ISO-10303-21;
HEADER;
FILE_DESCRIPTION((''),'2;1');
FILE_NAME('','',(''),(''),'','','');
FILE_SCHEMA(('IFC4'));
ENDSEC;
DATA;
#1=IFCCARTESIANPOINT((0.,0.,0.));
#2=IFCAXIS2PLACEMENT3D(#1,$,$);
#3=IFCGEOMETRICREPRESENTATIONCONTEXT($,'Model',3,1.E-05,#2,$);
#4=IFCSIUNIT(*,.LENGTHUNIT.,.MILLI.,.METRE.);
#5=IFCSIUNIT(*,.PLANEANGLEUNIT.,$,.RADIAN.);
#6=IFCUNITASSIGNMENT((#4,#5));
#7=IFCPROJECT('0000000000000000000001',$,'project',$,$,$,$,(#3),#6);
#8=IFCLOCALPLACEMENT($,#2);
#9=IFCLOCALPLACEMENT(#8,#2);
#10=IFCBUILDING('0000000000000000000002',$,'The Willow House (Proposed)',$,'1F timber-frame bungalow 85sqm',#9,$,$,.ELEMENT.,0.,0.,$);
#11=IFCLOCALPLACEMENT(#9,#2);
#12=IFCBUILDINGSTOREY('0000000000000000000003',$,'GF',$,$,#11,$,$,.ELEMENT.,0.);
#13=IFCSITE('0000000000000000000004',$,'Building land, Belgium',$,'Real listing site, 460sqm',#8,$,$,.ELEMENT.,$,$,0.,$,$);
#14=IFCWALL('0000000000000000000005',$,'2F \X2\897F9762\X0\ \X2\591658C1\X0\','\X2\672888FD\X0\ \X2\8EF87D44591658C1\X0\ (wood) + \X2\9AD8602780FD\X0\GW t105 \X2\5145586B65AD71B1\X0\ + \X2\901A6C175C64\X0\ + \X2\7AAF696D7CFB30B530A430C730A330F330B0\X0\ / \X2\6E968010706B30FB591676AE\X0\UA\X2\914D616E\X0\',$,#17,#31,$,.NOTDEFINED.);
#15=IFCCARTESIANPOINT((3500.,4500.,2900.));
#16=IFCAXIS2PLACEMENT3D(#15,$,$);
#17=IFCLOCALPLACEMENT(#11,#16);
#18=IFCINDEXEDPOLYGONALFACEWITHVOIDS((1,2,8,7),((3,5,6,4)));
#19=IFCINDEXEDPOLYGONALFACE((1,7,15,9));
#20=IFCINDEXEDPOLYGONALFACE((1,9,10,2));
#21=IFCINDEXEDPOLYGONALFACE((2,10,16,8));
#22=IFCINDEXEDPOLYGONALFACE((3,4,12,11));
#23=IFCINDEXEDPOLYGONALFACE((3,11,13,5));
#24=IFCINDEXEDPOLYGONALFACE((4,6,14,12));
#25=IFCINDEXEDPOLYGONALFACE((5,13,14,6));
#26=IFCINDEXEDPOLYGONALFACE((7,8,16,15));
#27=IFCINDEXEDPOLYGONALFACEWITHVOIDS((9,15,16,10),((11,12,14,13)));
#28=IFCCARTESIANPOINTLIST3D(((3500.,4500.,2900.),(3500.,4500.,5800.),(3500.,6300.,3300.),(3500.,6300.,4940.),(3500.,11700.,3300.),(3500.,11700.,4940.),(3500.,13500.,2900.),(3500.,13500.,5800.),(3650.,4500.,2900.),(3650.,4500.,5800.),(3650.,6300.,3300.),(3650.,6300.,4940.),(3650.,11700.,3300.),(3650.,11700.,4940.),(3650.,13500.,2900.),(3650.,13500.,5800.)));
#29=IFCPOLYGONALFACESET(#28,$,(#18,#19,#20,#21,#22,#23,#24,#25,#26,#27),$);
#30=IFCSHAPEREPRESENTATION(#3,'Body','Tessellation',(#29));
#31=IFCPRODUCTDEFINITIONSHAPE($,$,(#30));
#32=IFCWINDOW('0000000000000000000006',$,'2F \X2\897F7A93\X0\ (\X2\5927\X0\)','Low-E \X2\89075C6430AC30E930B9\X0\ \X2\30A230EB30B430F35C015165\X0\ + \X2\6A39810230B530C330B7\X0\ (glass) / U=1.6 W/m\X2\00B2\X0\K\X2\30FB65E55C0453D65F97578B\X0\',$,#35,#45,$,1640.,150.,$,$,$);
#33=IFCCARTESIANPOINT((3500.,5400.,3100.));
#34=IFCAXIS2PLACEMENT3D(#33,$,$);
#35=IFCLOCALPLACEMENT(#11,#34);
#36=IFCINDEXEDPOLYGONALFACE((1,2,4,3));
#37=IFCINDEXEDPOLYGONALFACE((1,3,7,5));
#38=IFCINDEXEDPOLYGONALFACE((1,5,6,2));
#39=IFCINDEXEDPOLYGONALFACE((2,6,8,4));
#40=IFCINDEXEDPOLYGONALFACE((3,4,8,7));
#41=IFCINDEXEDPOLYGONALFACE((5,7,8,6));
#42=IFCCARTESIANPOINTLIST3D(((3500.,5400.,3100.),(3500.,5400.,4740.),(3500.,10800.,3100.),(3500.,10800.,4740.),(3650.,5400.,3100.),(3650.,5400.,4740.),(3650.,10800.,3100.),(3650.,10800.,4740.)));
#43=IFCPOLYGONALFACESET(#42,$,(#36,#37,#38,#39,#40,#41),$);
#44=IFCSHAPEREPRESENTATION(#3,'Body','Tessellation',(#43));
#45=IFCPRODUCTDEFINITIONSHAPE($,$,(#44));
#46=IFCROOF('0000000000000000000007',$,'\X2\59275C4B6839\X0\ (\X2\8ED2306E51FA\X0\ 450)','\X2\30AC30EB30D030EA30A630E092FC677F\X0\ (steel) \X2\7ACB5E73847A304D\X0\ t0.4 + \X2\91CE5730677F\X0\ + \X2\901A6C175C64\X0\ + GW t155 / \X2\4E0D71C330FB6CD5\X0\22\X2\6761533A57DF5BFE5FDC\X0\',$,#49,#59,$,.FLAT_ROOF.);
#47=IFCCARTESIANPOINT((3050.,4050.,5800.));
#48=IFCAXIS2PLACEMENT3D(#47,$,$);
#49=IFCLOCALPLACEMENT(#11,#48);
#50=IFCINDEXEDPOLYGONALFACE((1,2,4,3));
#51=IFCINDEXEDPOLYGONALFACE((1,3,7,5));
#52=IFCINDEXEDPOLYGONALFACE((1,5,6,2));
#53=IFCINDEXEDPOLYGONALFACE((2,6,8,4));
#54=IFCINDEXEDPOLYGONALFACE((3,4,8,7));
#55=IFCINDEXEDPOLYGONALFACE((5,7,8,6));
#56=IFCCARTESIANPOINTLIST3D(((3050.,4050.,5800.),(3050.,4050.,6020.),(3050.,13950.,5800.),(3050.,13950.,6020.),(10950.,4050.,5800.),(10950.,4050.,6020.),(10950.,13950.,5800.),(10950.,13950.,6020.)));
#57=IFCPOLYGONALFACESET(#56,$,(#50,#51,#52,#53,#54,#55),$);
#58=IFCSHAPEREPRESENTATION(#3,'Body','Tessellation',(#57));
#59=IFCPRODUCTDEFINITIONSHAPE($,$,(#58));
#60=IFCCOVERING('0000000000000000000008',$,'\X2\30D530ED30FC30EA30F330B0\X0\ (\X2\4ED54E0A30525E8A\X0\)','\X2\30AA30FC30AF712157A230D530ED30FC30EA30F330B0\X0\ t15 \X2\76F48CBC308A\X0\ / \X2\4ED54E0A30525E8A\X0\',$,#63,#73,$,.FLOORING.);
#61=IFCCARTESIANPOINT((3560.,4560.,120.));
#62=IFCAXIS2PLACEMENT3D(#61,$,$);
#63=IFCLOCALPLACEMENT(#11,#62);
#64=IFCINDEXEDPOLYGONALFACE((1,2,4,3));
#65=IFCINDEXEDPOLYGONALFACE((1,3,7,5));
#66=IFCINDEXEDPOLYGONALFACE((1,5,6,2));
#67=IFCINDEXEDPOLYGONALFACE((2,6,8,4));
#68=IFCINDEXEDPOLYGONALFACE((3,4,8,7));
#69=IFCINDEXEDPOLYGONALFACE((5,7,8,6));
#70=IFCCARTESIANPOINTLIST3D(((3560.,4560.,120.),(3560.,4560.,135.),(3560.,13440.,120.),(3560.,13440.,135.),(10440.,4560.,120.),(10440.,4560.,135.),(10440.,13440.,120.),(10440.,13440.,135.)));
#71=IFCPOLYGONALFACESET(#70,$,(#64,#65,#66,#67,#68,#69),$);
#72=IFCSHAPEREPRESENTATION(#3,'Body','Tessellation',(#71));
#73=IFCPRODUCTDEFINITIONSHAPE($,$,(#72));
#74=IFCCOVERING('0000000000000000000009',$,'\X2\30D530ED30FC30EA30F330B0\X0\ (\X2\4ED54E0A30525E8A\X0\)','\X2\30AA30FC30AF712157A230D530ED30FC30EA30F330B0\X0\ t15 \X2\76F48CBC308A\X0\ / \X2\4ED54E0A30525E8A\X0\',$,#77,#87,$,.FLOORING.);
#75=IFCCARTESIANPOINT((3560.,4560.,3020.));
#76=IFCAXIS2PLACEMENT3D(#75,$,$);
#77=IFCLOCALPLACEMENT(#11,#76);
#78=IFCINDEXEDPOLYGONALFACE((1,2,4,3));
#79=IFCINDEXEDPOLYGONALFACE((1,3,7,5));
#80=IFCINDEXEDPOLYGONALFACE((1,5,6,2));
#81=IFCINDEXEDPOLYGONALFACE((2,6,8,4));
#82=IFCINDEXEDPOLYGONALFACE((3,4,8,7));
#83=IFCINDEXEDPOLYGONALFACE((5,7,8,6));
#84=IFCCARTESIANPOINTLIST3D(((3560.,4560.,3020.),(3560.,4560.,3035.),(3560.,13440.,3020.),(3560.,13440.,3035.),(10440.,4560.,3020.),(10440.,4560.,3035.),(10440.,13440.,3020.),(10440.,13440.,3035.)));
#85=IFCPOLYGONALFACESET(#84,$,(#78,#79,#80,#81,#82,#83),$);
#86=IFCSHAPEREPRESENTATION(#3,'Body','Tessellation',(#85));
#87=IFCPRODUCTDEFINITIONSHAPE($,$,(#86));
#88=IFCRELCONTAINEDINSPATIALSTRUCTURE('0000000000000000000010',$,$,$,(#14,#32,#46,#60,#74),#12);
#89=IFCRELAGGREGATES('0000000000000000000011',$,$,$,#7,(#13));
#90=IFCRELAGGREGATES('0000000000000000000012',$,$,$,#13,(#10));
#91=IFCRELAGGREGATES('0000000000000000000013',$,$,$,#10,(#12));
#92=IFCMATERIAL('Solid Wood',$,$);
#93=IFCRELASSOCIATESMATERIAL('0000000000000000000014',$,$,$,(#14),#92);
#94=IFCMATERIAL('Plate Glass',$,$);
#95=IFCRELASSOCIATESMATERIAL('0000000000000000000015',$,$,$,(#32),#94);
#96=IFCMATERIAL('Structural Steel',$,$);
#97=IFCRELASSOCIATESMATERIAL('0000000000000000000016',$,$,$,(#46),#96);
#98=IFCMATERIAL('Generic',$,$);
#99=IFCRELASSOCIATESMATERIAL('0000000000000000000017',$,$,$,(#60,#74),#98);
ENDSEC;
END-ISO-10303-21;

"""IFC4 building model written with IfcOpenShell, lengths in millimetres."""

from ifc_helpers import new_model, si_unit, frame, frame_2d, origin, place, context, project, spatial, rectangle, extrude, material, element, fill, save


model = new_model("IFC4")

# Units and contexts
model_context = context("Model", 3, precision=1e-05, world=origin())
ifc_project = project(units=[si_unit("LENGTHUNIT", "METRE", prefix="MILLI"), si_unit("PLANEANGLEUNIT", "RADIAN")], contexts=[model_context])

# Site, building, storey
site_placement = place(None, origin())
site = spatial("IfcSite", under=ifc_project, at=site_placement, Name="Building land, Belgium", ObjectType="Real listing site, 460sqm", CompositionType="ELEMENT", RefElevation=0.0)
building_placement = place(site_placement, origin())
building = spatial("IfcBuilding", under=site, at=building_placement, Name="The Willow House (Proposed)", ObjectType="1F timber-frame bungalow 85sqm", CompositionType="ELEMENT", ElevationOfRefHeight=0.0, ElevationOfTerrain=0.0)
storey_placement = place(building_placement, origin())
storey = spatial("IfcBuildingStorey", under=building, at=storey_placement, Name="GF", CompositionType="ELEMENT", Elevation=0.0)

# Shared definitions
ifc_material_1 = material(Name="Solid Wood")
ifc_material_2 = material(Name="Generic")

# Shared definitions
ifc_material_3 = material(Name="Plate Glass")

# Wall, opening, window
wall_1_placement = place(storey_placement, frame((3500.0, 4500.0, 2900.0)))
wall_1 = element("IfcWall", 1, at=wall_1_placement, inside=storey, material=ifc_material_1, Name="2F 西面 外壁", Description="木製 軸組外壁 (wood) + 高性能GW t105 充填断熱 + 通気層 + 窯業系サイディング / 準耐火・外皮UA配慮", PredefinedType="NOTDEFINED", context=model_context, shape_type="SweptSolid", body=[
    extrude(rectangle(XDim=150.0, YDim=9000.0, at=frame_2d((75.0, 4500.0))), frame((3500.0, 4500.0, 2900.0)), (0.0, 0.0, 1.0), 2900.0),
])
opening_1_placement = place(storey_placement, frame((3500.0, 5400.0, 3100.0)))
opening_1 = element("IfcOpeningElement", 2, at=opening_1_placement, cuts=wall_1, PredefinedType="NOTDEFINED", context=model_context, shape_type="SweptSolid", body=[
    extrude(rectangle(XDim=150.0, YDim=5400.0, at=frame_2d((75.0, 2700.0))), frame((3500.0, 5400.0, 3100.0)), (0.0, 0.0, 1.0), 1640.0),
])
window_1_placement = place(storey_placement, frame((3500.0, 5400.0, 3100.0)))
window_1 = element("IfcWindow", 3, at=window_1_placement, inside=storey, material=ifc_material_3, Name="2F 西窓 (大)", Description="Low-E 複層ガラス アルゴン封入 + 樹脂サッシ (glass) / U=1.6 W/m²K・日射取得型", OverallHeight=1640.0, OverallWidth=150.0, context=model_context, shape_type="SweptSolid", body=[
    extrude(rectangle(XDim=150.0, YDim=5400.0, at=frame_2d((75.0, 2700.0))), frame((3500.0, 5400.0, 3100.0)), (0.0, 0.0, 1.0), 1640.0),
])
fill(opening_1, window_1)

# Roof
ifc_material_4 = material(Name="Structural Steel")
roof_placement = place(storey_placement, frame((3050.0, 4050.0, 5800.0)))
element("IfcRoof", 4, at=roof_placement, inside=storey, material=ifc_material_4, Name="大屋根 (軒の出 450)", Description="ガルバリウム鋼板 (steel) 立平葺き t0.4 + 野地板 + 通気層 + GW t155 / 不燃・法22条区域対応", PredefinedType="FLAT_ROOF", context=model_context, shape_type="SweptSolid", body=[
    extrude(rectangle(XDim=7900.0, YDim=9900.0, at=frame_2d((3950.0, 4950.0))), frame((3050.0, 4050.0, 5800.0)), (0.0, 0.0, 1.0), 220.0),
])

# Coverings
covering_1_placement = place(storey_placement, frame((3560.0, 4560.0, 120.0)))
element("IfcCovering", 5, at=covering_1_placement, inside=storey, material=ifc_material_2, Name="フローリング (仕上げ床)", Description="オーク無垢フローリング t15 直貼り / 仕上げ床", PredefinedType="FLOORING", context=model_context, shape_type="SweptSolid", body=[
    extrude(rectangle(XDim=6880.0, YDim=8880.0, at=frame_2d((3440.0, 4440.0))), frame((3560.0, 4560.0, 120.0)), (0.0, 0.0, 1.0), 15.0),
])
covering_2_placement = place(storey_placement, frame((3560.0, 4560.0, 3020.0)))
element("IfcCovering", 6, at=covering_2_placement, inside=storey, material=ifc_material_2, Name="フローリング (仕上げ床)", Description="オーク無垢フローリング t15 直貼り / 仕上げ床", PredefinedType="FLOORING", context=model_context, shape_type="SweptSolid", body=[
    extrude(rectangle(XDim=6880.0, YDim=8880.0, at=frame_2d((3440.0, 4440.0))), frame((3560.0, 4560.0, 3020.0)), (0.0, 0.0, 1.0), 15.0),
])

save(model, "model.ifc")
